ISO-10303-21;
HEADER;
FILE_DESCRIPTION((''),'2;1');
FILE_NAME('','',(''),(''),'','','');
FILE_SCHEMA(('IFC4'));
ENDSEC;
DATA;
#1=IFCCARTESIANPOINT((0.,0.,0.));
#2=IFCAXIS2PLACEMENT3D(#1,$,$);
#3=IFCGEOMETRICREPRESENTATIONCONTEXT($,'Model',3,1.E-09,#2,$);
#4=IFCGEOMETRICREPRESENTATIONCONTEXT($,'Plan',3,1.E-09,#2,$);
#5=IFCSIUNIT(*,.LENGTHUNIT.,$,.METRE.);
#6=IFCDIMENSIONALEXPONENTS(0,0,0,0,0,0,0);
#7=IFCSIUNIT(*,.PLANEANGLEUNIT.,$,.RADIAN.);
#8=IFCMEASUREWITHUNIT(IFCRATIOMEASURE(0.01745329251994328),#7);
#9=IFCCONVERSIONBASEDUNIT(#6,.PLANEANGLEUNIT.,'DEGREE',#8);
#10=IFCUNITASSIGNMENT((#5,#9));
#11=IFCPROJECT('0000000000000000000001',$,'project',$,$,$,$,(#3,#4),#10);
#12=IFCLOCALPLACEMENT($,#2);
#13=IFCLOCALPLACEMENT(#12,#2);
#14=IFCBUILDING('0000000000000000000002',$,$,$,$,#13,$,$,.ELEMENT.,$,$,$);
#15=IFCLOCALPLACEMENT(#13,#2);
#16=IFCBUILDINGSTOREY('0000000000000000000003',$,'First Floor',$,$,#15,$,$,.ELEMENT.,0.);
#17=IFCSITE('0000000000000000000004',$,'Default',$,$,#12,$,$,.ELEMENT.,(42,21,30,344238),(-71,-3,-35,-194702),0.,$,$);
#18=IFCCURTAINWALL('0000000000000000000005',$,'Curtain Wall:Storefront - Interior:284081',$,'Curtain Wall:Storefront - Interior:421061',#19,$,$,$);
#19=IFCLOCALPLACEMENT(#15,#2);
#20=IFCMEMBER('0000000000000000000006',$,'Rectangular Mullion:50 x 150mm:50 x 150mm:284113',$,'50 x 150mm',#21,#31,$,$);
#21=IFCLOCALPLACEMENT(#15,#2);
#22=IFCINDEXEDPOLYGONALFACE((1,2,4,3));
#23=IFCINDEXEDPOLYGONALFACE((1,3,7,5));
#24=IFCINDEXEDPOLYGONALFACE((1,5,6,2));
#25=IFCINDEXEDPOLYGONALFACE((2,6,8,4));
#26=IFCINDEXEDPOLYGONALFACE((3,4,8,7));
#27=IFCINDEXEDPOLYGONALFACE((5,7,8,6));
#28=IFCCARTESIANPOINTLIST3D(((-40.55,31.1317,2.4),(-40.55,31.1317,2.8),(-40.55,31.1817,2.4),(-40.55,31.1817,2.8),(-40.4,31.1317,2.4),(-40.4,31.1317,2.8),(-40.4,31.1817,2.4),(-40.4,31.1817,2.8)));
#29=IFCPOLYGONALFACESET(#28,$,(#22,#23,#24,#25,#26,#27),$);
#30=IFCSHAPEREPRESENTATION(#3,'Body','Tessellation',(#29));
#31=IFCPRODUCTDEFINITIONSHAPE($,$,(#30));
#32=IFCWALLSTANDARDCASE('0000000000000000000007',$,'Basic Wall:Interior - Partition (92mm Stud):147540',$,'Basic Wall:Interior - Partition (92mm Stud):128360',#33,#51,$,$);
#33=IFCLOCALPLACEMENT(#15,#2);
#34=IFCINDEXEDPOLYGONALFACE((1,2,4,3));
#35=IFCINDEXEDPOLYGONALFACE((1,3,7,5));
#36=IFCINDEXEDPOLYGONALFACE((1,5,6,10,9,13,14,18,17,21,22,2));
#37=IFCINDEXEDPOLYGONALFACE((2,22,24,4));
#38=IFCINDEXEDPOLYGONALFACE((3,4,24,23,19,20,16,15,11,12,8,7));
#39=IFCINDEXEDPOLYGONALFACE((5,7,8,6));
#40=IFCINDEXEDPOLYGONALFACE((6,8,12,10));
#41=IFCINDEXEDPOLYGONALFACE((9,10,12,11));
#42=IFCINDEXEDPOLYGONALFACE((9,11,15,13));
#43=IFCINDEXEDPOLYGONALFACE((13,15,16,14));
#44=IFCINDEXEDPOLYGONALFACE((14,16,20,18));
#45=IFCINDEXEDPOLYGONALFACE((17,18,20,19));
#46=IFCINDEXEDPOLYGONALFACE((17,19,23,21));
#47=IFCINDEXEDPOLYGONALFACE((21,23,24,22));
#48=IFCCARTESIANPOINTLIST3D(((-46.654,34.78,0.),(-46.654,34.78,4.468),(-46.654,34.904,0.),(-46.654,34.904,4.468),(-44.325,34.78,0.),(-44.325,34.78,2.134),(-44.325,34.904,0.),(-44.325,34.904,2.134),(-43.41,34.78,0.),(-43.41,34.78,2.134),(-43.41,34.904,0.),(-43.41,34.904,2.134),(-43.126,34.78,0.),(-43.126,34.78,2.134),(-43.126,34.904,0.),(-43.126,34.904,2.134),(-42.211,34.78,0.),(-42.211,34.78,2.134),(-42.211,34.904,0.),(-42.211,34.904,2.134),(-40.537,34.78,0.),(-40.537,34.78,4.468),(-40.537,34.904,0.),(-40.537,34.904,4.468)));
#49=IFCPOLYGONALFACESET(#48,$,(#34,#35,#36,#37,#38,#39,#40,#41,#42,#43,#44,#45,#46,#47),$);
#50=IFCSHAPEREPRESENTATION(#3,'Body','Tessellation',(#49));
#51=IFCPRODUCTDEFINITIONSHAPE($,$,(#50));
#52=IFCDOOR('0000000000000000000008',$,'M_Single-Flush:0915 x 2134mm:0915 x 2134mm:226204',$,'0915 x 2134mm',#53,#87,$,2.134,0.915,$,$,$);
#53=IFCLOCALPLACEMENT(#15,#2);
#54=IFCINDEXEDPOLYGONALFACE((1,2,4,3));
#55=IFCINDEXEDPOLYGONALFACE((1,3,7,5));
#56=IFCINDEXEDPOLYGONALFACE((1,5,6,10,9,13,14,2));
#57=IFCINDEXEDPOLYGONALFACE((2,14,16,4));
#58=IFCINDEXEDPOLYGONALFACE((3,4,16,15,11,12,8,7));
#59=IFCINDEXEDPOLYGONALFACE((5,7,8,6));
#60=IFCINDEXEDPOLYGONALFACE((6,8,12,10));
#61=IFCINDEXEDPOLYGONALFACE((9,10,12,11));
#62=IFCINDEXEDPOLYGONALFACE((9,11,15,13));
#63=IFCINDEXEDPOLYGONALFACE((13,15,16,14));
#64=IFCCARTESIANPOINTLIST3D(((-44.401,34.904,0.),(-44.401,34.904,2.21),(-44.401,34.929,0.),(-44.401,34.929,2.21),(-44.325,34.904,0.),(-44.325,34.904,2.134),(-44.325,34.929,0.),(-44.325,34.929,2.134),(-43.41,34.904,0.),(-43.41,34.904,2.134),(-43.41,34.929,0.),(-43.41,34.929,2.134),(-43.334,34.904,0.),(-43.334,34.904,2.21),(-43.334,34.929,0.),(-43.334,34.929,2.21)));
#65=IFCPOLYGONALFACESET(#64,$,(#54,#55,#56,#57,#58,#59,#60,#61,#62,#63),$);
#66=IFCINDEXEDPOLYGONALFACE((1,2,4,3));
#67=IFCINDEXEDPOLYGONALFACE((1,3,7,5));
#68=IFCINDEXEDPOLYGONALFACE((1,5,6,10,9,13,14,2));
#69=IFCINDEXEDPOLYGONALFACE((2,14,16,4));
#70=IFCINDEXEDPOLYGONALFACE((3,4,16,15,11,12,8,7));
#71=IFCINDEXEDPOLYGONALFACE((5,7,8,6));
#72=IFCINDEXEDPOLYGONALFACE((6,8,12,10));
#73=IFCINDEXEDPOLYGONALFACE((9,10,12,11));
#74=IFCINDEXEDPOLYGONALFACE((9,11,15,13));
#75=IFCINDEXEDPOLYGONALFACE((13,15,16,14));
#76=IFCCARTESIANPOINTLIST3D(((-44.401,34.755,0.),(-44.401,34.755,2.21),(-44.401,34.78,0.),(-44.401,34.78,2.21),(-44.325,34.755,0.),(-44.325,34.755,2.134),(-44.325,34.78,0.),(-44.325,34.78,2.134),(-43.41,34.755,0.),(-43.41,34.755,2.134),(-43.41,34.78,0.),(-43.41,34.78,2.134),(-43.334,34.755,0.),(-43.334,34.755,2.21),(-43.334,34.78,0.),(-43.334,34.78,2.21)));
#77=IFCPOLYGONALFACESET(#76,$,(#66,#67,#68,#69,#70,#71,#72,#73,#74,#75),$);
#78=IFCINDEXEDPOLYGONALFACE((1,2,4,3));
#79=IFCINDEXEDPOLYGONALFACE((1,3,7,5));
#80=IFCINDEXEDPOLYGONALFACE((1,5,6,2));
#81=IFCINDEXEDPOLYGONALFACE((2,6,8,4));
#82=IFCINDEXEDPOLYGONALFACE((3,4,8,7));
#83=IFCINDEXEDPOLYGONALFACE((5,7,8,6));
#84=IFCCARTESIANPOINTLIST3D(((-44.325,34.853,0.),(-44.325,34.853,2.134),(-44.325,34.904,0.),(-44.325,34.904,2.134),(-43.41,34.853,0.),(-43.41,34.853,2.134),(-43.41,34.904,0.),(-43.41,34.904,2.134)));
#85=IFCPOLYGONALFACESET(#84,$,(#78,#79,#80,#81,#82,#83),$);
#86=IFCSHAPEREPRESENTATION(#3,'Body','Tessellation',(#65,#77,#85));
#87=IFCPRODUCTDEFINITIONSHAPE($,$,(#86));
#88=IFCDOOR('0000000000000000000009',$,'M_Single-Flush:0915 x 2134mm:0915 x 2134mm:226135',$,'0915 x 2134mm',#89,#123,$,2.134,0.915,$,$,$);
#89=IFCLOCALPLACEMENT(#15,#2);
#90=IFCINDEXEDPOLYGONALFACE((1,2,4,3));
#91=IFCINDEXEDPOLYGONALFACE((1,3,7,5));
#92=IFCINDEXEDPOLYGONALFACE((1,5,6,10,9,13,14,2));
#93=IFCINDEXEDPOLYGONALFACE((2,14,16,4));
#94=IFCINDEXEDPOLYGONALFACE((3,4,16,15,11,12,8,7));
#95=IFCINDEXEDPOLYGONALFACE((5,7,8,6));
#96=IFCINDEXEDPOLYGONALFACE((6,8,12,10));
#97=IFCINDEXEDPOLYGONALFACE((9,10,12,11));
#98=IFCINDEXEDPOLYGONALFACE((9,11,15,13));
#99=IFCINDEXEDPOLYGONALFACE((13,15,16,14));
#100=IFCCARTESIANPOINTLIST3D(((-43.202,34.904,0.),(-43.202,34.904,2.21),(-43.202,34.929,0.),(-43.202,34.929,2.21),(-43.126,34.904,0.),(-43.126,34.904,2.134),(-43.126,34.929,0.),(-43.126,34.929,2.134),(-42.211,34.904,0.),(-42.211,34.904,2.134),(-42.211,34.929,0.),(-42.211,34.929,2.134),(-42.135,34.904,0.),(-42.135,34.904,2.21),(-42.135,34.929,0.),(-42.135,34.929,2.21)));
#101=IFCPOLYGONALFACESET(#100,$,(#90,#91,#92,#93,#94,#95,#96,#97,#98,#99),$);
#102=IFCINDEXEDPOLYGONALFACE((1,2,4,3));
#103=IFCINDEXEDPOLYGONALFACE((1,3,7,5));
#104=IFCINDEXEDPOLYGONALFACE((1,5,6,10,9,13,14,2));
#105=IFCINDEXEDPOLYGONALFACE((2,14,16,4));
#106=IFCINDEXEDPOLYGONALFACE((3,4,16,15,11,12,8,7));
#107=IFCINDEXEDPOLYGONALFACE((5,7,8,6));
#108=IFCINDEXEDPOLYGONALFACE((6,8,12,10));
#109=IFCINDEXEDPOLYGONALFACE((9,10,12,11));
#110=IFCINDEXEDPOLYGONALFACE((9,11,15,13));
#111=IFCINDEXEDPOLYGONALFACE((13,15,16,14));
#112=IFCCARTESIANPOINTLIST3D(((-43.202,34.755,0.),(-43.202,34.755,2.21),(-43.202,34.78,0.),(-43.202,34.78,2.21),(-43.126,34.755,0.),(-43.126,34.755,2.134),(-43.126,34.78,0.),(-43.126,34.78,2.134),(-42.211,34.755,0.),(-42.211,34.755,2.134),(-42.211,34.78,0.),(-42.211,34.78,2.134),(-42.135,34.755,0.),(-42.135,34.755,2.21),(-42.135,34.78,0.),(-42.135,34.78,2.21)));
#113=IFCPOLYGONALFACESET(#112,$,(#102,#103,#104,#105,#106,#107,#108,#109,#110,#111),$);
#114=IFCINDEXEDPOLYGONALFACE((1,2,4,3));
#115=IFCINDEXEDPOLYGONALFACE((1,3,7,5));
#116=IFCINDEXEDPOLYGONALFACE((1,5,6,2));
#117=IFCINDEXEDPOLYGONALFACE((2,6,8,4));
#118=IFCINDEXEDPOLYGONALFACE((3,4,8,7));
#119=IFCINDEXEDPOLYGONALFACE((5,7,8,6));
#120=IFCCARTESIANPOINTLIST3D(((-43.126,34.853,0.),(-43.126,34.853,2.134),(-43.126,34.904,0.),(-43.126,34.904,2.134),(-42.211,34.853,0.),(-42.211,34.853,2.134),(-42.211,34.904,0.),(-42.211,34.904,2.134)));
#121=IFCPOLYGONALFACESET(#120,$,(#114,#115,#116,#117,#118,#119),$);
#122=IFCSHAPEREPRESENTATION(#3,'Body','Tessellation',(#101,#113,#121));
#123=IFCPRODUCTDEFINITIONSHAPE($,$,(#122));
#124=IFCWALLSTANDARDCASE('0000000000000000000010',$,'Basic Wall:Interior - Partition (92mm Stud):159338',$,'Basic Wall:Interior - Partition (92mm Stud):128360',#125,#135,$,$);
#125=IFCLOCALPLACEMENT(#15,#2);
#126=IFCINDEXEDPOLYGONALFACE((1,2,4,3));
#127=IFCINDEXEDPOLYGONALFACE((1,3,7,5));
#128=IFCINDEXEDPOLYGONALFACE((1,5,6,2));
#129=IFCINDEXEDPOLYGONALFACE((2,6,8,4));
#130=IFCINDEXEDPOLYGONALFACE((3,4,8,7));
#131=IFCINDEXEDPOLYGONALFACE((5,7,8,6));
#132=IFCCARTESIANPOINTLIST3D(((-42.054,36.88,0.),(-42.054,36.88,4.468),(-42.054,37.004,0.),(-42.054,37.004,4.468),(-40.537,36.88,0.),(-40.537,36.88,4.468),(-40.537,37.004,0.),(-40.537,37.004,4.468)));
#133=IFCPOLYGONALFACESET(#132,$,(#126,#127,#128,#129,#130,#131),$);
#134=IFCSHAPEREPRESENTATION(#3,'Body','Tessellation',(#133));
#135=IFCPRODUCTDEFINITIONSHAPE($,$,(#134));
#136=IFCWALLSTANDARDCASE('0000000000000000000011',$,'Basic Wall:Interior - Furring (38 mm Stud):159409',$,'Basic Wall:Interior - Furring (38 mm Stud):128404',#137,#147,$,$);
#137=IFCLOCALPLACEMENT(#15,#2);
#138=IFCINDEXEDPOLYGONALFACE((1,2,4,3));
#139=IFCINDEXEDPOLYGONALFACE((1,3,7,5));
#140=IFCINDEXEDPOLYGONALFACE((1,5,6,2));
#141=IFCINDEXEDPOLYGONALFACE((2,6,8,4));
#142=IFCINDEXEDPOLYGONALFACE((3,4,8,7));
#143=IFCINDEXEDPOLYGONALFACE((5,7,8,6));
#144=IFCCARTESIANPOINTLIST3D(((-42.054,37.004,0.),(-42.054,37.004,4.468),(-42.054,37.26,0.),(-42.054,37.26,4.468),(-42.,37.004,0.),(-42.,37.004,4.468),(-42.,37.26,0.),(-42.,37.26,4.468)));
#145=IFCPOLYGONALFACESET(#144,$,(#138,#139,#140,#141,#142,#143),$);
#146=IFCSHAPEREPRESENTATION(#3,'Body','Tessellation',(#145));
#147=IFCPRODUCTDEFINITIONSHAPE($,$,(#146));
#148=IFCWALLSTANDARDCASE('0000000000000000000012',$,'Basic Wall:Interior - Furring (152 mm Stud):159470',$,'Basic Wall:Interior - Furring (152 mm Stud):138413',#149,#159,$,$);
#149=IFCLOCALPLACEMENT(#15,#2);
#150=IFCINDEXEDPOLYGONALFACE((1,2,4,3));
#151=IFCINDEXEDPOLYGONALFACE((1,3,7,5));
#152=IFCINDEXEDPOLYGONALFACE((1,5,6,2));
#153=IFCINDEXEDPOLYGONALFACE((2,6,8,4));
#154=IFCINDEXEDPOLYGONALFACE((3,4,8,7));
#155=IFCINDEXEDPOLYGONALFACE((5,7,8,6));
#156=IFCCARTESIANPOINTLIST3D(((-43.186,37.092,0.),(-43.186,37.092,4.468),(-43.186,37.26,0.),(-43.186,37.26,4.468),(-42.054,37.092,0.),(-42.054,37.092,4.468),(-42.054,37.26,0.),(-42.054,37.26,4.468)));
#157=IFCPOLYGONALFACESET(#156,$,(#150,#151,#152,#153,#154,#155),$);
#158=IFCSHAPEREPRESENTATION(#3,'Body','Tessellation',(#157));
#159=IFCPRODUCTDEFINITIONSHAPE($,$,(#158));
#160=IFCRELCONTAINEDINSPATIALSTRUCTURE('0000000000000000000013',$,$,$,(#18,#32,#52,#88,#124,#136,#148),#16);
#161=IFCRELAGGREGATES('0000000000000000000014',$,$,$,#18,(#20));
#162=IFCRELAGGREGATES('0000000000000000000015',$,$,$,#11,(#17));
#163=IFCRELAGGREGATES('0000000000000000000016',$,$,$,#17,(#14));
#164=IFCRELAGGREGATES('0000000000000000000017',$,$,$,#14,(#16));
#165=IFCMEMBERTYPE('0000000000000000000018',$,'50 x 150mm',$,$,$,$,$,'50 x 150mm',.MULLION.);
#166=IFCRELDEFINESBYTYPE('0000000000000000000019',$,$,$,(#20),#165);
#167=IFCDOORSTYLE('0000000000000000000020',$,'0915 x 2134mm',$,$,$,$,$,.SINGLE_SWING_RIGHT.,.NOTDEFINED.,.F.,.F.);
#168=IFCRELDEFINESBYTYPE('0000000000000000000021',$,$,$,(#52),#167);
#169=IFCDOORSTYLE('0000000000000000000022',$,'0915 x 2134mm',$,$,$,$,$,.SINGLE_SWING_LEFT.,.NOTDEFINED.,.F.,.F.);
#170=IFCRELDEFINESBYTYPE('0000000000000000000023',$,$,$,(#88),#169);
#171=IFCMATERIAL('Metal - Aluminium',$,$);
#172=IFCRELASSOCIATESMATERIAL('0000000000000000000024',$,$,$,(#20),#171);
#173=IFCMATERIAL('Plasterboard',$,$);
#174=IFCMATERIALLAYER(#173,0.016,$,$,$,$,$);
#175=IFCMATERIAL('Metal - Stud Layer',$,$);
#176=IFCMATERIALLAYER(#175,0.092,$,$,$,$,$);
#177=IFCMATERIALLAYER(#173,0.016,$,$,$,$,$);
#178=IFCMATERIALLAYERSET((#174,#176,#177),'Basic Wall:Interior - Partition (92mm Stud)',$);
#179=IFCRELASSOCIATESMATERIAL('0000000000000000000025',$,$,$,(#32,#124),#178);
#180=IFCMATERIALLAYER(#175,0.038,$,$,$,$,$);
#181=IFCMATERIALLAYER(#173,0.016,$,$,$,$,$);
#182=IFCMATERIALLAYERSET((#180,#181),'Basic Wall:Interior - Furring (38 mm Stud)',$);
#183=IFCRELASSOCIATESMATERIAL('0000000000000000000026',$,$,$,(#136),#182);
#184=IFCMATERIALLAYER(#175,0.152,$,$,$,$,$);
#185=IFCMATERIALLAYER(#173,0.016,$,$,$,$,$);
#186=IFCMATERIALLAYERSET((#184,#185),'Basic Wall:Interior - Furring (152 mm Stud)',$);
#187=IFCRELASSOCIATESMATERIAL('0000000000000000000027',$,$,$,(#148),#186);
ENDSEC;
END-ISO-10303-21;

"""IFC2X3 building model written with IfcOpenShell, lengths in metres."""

from ifc_helpers import new_model, entity, si_unit, converted_unit, frame, frame_2d, origin, origin_2d_with_axis, place, context, project, spatial, polyline, rectangle, outline, extrude, source, transform, mapped, material, layer, layer_set, layer_usage, type_object, type_shapes, element, fill, aggregate, save


model = new_model("IFC2X3")

# Units and contexts
model_context = context("Model", 3, precision=1e-09, world=origin())
plan_context = context("Plan", 3, precision=1e-09, world=origin())
ifc_project = project(units=[si_unit("LENGTHUNIT", "METRE"), converted_unit("PLANEANGLEUNIT", "DEGREE", entity("IfcRatioMeasure", 0.01745329251994328), si_unit("PLANEANGLEUNIT", "RADIAN"), dimensions=[0, 0, 0, 0, 0, 0, 0])], contexts=[model_context, plan_context])

# Site, building, storey
site_placement = place(None, origin())
site = spatial("IfcSite", under=ifc_project, at=site_placement, Name="Default", CompositionType="ELEMENT", RefLatitude=(42, 21, 30, 344238), RefLongitude=(-71, -3, -35, -194702), RefElevation=0.0)
building_placement = place(site_placement, origin())
building = spatial("IfcBuilding", under=site, at=building_placement, CompositionType="ELEMENT")
storey_placement = place(building_placement, origin())
storey = spatial("IfcBuildingStorey", under=building, at=storey_placement, Name="First Floor", CompositionType="ELEMENT", Elevation=0.0)

# Curtain wall, member
curtain_wall_placement = place(storey_placement, origin())
curtain_wall = element("IfcCurtainWall", 1, at=curtain_wall_placement, inside=storey, Name="Curtain Wall:Storefront - Interior:284081", ObjectType="Curtain Wall:Storefront - Interior:421061")
ifc_material_1 = material(Name="Metal - Aluminium")
member_type_1 = type_object("IfcMemberType", Name="50 x 150mm", ElementType="50 x 150mm", PredefinedType="MULLION")
shared_shape_1 = source(origin(), model_context, "Body", "SweptSolid", [
    extrude(rectangle(XDim=0.05, YDim=0.15, at=origin_2d_with_axis()), frame((0.0, 0.0, -0.4), z_axis=(0.0, 0.0, 1.0), x_axis=(-1.0, 0.0, 0.0)), (0.0, 0.0, 1.0), 0.4),
])
type_shapes(member_type_1, [shared_shape_1])
member_1_placement = place(storey_placement, frame((-40.475, 31.1567, 2.4), z_axis=(0.0, 0.0, -1.0), x_axis=(0.0, -1.0, 0.0)))
member_1 = element("IfcMember", 2, at=member_1_placement, type_object=member_type_1, material=ifc_material_1, Name="Rectangular Mullion:50 x 150mm:50 x 150mm:284113", ObjectType="50 x 150mm", context=model_context, shape_type="MappedRepresentation", body=[
    mapped(shared_shape_1, transform((0.0, 0.0, 0.0), scale=1.0)),
])
aggregate(curtain_wall, [member_1])

# Wall, openings, doors
ifc_material_2 = material(Name="Plasterboard")
ifc_layer_1 = layer(ifc_material_2, 0.016)
ifc_material_3 = material(Name="Metal - Stud Layer")
ifc_layer_2 = layer(ifc_material_3, 0.092)
ifc_layer_3 = layer(ifc_material_2, 0.016)
ifc_layer_set_1 = layer_set([ifc_layer_1, ifc_layer_2, ifc_layer_3], Name="Basic Wall:Interior - Partition (92mm Stud)")
ifc_layer_usage_1 = layer_usage(ifc_layer_set_1, "AXIS2", "NEGATIVE", 0.062)
wall_1_placement = place(storey_placement, frame((-40.537, 34.842, 0.0), z_axis=(0.0, 0.0, 1.0), x_axis=(-1.0, 0.0, 0.0)))
wall_1 = element("IfcWallStandardCase", 3, at=wall_1_placement, inside=storey, material=ifc_layer_usage_1, Name="Basic Wall:Interior - Partition (92mm Stud):147540", ObjectType="Basic Wall:Interior - Partition (92mm Stud):128360", context=model_context, shape_type="SweptSolid", body=[
    extrude(rectangle(XDim=6.117, YDim=0.124, at=frame_2d((3.0585, 0.0), x_axis=(-1.0, 0.0))), origin(), (0.0, 0.0, 1.0), 4.468),
])
opening_1_placement = place(wall_1_placement, frame((2.589, 0.062, 0.0)))
opening_1 = element("IfcOpeningElement", 4, at=opening_1_placement, cuts=wall_1, ObjectType="Opening", context=model_context, shape_type="SweptSolid", body=[
    extrude(rectangle(XDim=0.915, YDim=2.134, at=frame_2d((1.067, 0.4575), x_axis=(0.0, -1.0))), frame((0.0, 0.0, 0.0), z_axis=(0.0, -1.0, 0.0), x_axis=(0.0, 0.0, 1.0)), (0.0, 0.0, 1.0), 0.124),
])
opening_2_placement = place(wall_1_placement, frame((3.788, 0.062, 0.0)))
opening_2 = element("IfcOpeningElement", 5, at=opening_2_placement, cuts=wall_1, ObjectType="Opening", context=model_context, shape_type="SweptSolid", body=[
    extrude(rectangle(XDim=0.915, YDim=2.134, at=frame_2d((1.067, 0.4575), x_axis=(0.0, 1.0))), frame((0.0, 0.0, 0.0), z_axis=(0.0, -1.0, 0.0), x_axis=(0.0, 0.0, 1.0)), (0.0, 0.0, 1.0), 0.124),
])
door_style_1 = type_object("IfcDoorStyle", Name="0915 x 2134mm", ConstructionType="NOTDEFINED", OperationType="SINGLE_SWING_RIGHT", ParameterTakesPrecedence=False, Sizeable=False)
shared_shape_2 = source(origin(), model_context, "Body", "SweptSolid", [
    extrude(outline(polyline([(-0.5335, -1.124), (0.5335, -1.124), (0.5335, 1.086), (0.4575, 1.086), (0.4575, -1.048), (-0.4575, -1.048), (-0.4575, 1.086), (-0.5335, 1.086), (-0.5335, -1.124)])), frame((0.4575, 0.124, 1.086), z_axis=(0.0, 1.0, 0.0), x_axis=(1.0, 0.0, 0.0)), (0.0, 0.0, 1.0), 0.025),
    extrude(outline(polyline([(-1.124, -0.5335), (1.086, -0.5335), (1.086, -0.4575), (-1.048, -0.4575), (-1.048, 0.4575), (1.086, 0.4575), (1.086, 0.5335), (-1.124, 0.5335), (-1.124, -0.5335)])), frame((0.4575, -0.025, 1.086), z_axis=(0.0, 1.0, 0.0), x_axis=(0.0, 0.0, -1.0)), (0.0, 0.0, 1.0), 0.025),
    extrude(rectangle(XDim=0.051, YDim=0.915, at=origin_2d_with_axis()), frame((0.4575, 0.0985, 0.0), z_axis=(0.0, 0.0, 1.0), x_axis=(0.0, 1.0, 0.0)), (0.0, 0.0, 1.0), 2.134),
])
type_shapes(door_style_1, [shared_shape_2])
door_1_placement = place(opening_2_placement, frame((0.0, 0.0, 0.0), z_axis=(0.0, 0.0, 1.0), x_axis=(-1.0, 0.0, 0.0)))
door_1 = element("IfcDoor", 6, at=door_1_placement, inside=storey, type_object=door_style_1, Name="M_Single-Flush:0915 x 2134mm:0915 x 2134mm:226204", ObjectType="0915 x 2134mm", OverallHeight=2.134, OverallWidth=0.915, context=model_context, shape_type="MappedRepresentation", body=[
    mapped(shared_shape_2, transform((0.0, 0.0, 0.0), scale=1.0)),
])
fill(opening_2, door_1)
door_style_2 = type_object("IfcDoorStyle", Name="0915 x 2134mm", ConstructionType="NOTDEFINED", OperationType="SINGLE_SWING_LEFT", ParameterTakesPrecedence=False, Sizeable=False)
shared_shape_3 = source(origin(), model_context, "Body", "SweptSolid", [
    extrude(outline(polyline([(-0.5335, -1.124), (0.5335, -1.124), (0.5335, 1.086), (0.4575, 1.086), (0.4575, -1.048), (-0.4575, -1.048), (-0.4575, 1.086), (-0.5335, 1.086), (-0.5335, -1.124)])), frame((0.4575, 0.149, 1.086), z_axis=(0.0, -1.0, 0.0), x_axis=(-1.0, 0.0, 0.0)), (0.0, 0.0, 1.0), 0.025),
    extrude(outline(polyline([(-1.124, -0.5335), (1.086, -0.5335), (1.086, -0.4575), (-1.048, -0.4575), (-1.048, 0.4575), (1.086, 0.4575), (1.086, 0.5335), (-1.124, 0.5335), (-1.124, -0.5335)])), frame((0.4575, 0.0, 1.086), z_axis=(0.0, -1.0, 0.0), x_axis=(0.0, 0.0, -1.0)), (0.0, 0.0, 1.0), 0.025),
    extrude(rectangle(XDim=0.915, YDim=0.051, at=origin_2d_with_axis()), frame((0.4575, 0.0985, 0.0)), (0.0, 0.0, 1.0), 2.134),
])
type_shapes(door_style_2, [shared_shape_3])
door_2_placement = place(opening_1_placement, frame((0.0, 0.0, 0.0), z_axis=(0.0, 0.0, 1.0), x_axis=(-1.0, 0.0, 0.0)))
door_2 = element("IfcDoor", 7, at=door_2_placement, inside=storey, type_object=door_style_2, Name="M_Single-Flush:0915 x 2134mm:0915 x 2134mm:226135", ObjectType="0915 x 2134mm", OverallHeight=2.134, OverallWidth=0.915, context=model_context, shape_type="MappedRepresentation", body=[
    mapped(shared_shape_3, transform((0.0, 0.0, 0.0), scale=1.0)),
])
fill(opening_1, door_2)

# Walls
ifc_layer_usage_2 = layer_usage(ifc_layer_set_1, "AXIS2", "NEGATIVE", 0.062)
wall_2_placement = place(storey_placement, frame((-40.537, 36.942, 0.0), z_axis=(0.0, 0.0, 1.0), x_axis=(-1.0, 0.0, 0.0)))
element("IfcWallStandardCase", 8, at=wall_2_placement, inside=storey, material=ifc_layer_usage_2, Name="Basic Wall:Interior - Partition (92mm Stud):159338", ObjectType="Basic Wall:Interior - Partition (92mm Stud):128360", context=model_context, shape_type="SweptSolid", body=[
    extrude(rectangle(XDim=1.517, YDim=0.124, at=frame_2d((0.7585, 0.0), x_axis=(-1.0, 0.0))), origin(), (0.0, 0.0, 1.0), 4.468),
])
ifc_layer_4 = layer(ifc_material_3, 0.038)
ifc_layer_5 = layer(ifc_material_2, 0.016)
ifc_layer_set_2 = layer_set([ifc_layer_4, ifc_layer_5], Name="Basic Wall:Interior - Furring (38 mm Stud)")
ifc_layer_usage_3 = layer_usage(ifc_layer_set_2, "AXIS2", "POSITIVE", -0.027)
wall_3_placement = place(storey_placement, frame((-42.027, 37.26, 0.0), z_axis=(0.0, 0.0, 1.0), x_axis=(0.0, -1.0, 0.0)))
element("IfcWallStandardCase", 9, at=wall_3_placement, inside=storey, material=ifc_layer_usage_3, Name="Basic Wall:Interior - Furring (38 mm Stud):159409", ObjectType="Basic Wall:Interior - Furring (38 mm Stud):128404", context=model_context, shape_type="SweptSolid", body=[
    extrude(rectangle(XDim=0.256, YDim=0.054, at=frame_2d((0.128, 0.0), x_axis=(-1.0, 0.0))), origin(), (0.0, 0.0, 1.0), 4.468),
])
ifc_layer_6 = layer(ifc_material_3, 0.152)
ifc_layer_7 = layer(ifc_material_2, 0.016)
ifc_layer_set_3 = layer_set([ifc_layer_6, ifc_layer_7], Name="Basic Wall:Interior - Furring (152 mm Stud)")
ifc_layer_usage_4 = layer_usage(ifc_layer_set_3, "AXIS2", "POSITIVE", -0.084)
wall_4_placement = place(storey_placement, frame((-43.186, 37.176, 0.0)))
element("IfcWallStandardCase", 10, at=wall_4_placement, inside=storey, material=ifc_layer_usage_4, Name="Basic Wall:Interior - Furring (152 mm Stud):159470", ObjectType="Basic Wall:Interior - Furring (152 mm Stud):138413", context=model_context, shape_type="SweptSolid", body=[
    extrude(rectangle(XDim=1.132, YDim=0.168, at=frame_2d((0.566, 0.0), x_axis=(-1.0, 0.0))), origin(), (0.0, 0.0, 1.0), 4.468),
])

save(model, "model.ifc")
